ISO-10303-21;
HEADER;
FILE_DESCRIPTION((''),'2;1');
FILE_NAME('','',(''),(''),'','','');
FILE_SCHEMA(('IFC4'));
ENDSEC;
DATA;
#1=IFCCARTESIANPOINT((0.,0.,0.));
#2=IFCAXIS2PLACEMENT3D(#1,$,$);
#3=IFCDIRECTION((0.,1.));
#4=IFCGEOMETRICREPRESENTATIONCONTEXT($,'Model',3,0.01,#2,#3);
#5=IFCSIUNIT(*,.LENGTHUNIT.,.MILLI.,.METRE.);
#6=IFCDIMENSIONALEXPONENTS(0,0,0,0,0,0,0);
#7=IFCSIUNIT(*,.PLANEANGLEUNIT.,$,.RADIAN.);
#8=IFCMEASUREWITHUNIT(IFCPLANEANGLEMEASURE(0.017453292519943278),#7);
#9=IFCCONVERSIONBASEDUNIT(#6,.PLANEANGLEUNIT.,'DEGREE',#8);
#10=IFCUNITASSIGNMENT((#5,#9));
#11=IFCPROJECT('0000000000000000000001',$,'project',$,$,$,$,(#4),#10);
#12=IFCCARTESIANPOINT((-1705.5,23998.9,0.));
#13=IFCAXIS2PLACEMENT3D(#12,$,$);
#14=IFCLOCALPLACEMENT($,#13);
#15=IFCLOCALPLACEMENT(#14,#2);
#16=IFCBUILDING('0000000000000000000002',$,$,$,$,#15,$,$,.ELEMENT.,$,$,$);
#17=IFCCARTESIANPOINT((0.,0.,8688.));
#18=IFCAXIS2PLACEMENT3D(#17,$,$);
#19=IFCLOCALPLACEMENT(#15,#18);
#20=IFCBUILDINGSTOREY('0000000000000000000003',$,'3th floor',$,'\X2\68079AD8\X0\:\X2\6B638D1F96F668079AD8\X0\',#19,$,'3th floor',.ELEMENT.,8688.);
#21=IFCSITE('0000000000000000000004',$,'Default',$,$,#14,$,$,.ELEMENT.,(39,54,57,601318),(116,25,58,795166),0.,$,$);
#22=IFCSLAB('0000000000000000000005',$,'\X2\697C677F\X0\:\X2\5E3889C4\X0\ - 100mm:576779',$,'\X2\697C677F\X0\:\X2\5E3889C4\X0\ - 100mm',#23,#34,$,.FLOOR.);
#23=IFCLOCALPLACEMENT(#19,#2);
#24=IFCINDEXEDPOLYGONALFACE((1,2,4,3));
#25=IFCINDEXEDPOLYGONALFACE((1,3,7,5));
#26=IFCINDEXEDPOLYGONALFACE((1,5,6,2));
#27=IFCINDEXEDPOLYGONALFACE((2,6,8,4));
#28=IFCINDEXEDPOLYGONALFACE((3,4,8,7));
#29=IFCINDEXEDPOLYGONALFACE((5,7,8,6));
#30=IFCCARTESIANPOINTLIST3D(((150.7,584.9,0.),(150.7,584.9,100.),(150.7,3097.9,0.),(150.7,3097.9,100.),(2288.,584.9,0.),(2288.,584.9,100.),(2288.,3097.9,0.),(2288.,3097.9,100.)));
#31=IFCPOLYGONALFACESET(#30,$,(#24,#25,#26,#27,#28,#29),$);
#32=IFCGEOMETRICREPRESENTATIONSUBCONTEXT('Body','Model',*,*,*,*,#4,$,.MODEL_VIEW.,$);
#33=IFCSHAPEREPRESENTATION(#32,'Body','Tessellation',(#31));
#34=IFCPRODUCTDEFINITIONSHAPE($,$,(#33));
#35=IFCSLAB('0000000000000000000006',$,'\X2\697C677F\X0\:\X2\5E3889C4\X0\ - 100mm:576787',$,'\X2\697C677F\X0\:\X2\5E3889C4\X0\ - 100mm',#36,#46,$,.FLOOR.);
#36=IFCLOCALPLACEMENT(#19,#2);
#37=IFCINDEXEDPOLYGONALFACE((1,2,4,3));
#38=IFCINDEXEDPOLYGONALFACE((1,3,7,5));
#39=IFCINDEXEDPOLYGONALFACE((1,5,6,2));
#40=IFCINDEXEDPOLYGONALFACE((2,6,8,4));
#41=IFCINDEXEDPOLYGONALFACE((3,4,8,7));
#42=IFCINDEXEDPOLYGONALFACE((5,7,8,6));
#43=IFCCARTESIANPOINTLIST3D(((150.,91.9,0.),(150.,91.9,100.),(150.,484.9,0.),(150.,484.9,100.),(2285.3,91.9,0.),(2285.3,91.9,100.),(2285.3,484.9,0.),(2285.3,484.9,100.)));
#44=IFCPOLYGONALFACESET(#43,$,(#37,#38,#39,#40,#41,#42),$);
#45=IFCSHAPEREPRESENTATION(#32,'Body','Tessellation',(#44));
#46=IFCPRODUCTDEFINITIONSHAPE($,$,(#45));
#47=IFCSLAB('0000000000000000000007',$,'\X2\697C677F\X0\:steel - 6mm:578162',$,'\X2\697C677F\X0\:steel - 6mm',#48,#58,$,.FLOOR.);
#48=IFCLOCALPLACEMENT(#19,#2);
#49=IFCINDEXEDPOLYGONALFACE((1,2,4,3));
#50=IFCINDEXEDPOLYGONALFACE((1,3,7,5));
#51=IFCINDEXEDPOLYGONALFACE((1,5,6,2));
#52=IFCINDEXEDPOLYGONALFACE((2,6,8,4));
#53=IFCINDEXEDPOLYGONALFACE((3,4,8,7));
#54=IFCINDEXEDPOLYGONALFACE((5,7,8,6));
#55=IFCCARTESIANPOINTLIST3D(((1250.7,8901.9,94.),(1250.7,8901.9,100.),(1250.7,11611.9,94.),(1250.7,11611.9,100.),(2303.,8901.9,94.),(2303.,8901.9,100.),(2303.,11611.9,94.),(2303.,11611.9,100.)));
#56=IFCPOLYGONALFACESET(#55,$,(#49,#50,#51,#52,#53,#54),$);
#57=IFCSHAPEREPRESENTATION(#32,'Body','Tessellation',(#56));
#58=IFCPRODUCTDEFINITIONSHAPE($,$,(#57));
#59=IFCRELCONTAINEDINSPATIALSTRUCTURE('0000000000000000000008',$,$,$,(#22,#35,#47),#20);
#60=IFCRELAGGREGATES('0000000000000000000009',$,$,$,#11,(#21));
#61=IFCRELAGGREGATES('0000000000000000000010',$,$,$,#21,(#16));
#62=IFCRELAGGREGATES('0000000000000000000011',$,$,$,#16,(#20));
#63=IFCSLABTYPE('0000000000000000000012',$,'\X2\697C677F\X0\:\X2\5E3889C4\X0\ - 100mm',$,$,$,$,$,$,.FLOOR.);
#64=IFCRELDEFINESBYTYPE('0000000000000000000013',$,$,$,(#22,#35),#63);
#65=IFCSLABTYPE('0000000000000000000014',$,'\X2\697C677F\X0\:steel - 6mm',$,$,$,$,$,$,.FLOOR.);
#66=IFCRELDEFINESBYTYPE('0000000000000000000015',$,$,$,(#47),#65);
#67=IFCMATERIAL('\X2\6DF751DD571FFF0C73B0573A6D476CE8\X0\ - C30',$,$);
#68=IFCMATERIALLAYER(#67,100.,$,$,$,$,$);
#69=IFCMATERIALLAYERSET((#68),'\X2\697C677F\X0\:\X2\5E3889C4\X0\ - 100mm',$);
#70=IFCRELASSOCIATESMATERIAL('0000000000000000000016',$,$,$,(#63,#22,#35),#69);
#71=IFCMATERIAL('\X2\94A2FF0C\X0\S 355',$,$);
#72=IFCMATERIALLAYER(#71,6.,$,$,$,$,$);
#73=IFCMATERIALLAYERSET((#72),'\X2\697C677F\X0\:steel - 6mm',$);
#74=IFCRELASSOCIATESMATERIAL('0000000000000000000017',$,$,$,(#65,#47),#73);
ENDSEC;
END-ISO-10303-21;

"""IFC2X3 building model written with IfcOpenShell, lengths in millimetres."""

from ifc_helpers import new_model, entity, si_unit, converted_unit, direction, frame, frame_2d, origin, place, context, subcontext, project, spatial, rectangle, extrude, material, layer, layer_set, layer_usage, type_object, element, save


model = new_model("IFC2X3")

# Units and contexts
model_context = context("Model", 3, precision=0.01, world=origin(), true_north=direction((0.0, 1.0)))
body_context = subcontext(model_context, "Body", "Model", "MODEL_VIEW")
ifc_project = project(units=[si_unit("LENGTHUNIT", "METRE", prefix="MILLI"), converted_unit("PLANEANGLEUNIT", "DEGREE", entity("IfcPlaneAngleMeasure", 0.017453292519943278), si_unit("PLANEANGLEUNIT", "RADIAN"), dimensions=[0, 0, 0, 0, 0, 0, 0])], contexts=[model_context])

# Site, building, storey
site_placement = place(None, frame((-1705.5, 23998.9, 0.0)))
site = spatial("IfcSite", under=ifc_project, at=site_placement, Name="Default", CompositionType="ELEMENT", RefLatitude=(39, 54, 57, 601318), RefLongitude=(116, 25, 58, 795166), RefElevation=0.0)
building_placement = place(site_placement, origin())
building = spatial("IfcBuilding", under=site, at=building_placement, CompositionType="ELEMENT")
storey_placement = place(building_placement, frame((0.0, 0.0, 8688.0)))
storey = spatial("IfcBuildingStorey", under=building, at=storey_placement, Name="3th floor", ObjectType="标高:正负零标高", LongName="3th floor", CompositionType="ELEMENT", Elevation=8688.0)

# Slabs
ifc_material_1 = material(Name="混凝土，现场浇注 - C30")
ifc_layer_1 = layer(ifc_material_1, 100.0)
ifc_layer_set_1 = layer_set([ifc_layer_1], Name="楼板:常规 - 100mm")
slab_type_1 = type_object("IfcSlabType", Name="楼板:常规 - 100mm", PredefinedType="FLOOR", material=ifc_layer_set_1)
ifc_layer_usage_1 = layer_usage(ifc_layer_set_1, "AXIS3", "POSITIVE", 0.0)
slab_1_placement = place(storey_placement, origin())
element("IfcSlab", 1, at=slab_1_placement, inside=storey, type_object=slab_type_1, material=ifc_layer_usage_1, Name="楼板:常规 - 100mm:576779", ObjectType="楼板:常规 - 100mm", PredefinedType="FLOOR", context=body_context, shape_type="SweptSolid", body=[
    extrude(rectangle(XDim=2513.0, YDim=2137.3, at=frame_2d((0.0, 0.0), x_axis=(1.0, 0.0))), frame((1219.3, 1841.4, 100.0), z_axis=(0.0, 0.0, -1.0), x_axis=(0.0, 1.0, 0.0)), (0.0, 0.0, 1.0), 100.0),
])
ifc_layer_usage_2 = layer_usage(ifc_layer_set_1, "AXIS3", "POSITIVE", 0.0)
slab_2_placement = place(storey_placement, origin())
element("IfcSlab", 2, at=slab_2_placement, inside=storey, type_object=slab_type_1, material=ifc_layer_usage_2, Name="楼板:常规 - 100mm:576787", ObjectType="楼板:常规 - 100mm", PredefinedType="FLOOR", context=body_context, shape_type="SweptSolid", body=[
    extrude(rectangle(XDim=393.0, YDim=2135.3, at=frame_2d((0.0, 0.0), x_axis=(1.0, 0.0))), frame((1217.6, 288.4, 100.0), z_axis=(0.0, 0.0, -1.0), x_axis=(0.0, 1.0, 0.0)), (0.0, 0.0, 1.0), 100.0),
])
ifc_material_2 = material(Name="钢，S 355")
ifc_layer_2 = layer(ifc_material_2, 6.0)
ifc_layer_set_2 = layer_set([ifc_layer_2], Name="楼板:steel - 6mm")
ifc_layer_usage_3 = layer_usage(ifc_layer_set_2, "AXIS3", "POSITIVE", 0.0)
slab_type_2 = type_object("IfcSlabType", Name="楼板:steel - 6mm", PredefinedType="FLOOR", material=ifc_layer_set_2)
slab_3_placement = place(storey_placement, origin())
element("IfcSlab", 3, at=slab_3_placement, inside=storey, type_object=slab_type_2, material=ifc_layer_usage_3, Name="楼板:steel - 6mm:578162", ObjectType="楼板:steel - 6mm", PredefinedType="FLOOR", context=body_context, shape_type="SweptSolid", body=[
    extrude(rectangle(XDim=2710.0, YDim=1052.3, at=frame_2d((0.0, 0.0), x_axis=(1.0, 0.0))), frame((1776.8, 10256.9, 100.0), z_axis=(0.0, 0.0, -1.0), x_axis=(0.0, 1.0, 0.0)), (0.0, 0.0, 1.0), 6.0),
])

save(model, "model.ifc")
